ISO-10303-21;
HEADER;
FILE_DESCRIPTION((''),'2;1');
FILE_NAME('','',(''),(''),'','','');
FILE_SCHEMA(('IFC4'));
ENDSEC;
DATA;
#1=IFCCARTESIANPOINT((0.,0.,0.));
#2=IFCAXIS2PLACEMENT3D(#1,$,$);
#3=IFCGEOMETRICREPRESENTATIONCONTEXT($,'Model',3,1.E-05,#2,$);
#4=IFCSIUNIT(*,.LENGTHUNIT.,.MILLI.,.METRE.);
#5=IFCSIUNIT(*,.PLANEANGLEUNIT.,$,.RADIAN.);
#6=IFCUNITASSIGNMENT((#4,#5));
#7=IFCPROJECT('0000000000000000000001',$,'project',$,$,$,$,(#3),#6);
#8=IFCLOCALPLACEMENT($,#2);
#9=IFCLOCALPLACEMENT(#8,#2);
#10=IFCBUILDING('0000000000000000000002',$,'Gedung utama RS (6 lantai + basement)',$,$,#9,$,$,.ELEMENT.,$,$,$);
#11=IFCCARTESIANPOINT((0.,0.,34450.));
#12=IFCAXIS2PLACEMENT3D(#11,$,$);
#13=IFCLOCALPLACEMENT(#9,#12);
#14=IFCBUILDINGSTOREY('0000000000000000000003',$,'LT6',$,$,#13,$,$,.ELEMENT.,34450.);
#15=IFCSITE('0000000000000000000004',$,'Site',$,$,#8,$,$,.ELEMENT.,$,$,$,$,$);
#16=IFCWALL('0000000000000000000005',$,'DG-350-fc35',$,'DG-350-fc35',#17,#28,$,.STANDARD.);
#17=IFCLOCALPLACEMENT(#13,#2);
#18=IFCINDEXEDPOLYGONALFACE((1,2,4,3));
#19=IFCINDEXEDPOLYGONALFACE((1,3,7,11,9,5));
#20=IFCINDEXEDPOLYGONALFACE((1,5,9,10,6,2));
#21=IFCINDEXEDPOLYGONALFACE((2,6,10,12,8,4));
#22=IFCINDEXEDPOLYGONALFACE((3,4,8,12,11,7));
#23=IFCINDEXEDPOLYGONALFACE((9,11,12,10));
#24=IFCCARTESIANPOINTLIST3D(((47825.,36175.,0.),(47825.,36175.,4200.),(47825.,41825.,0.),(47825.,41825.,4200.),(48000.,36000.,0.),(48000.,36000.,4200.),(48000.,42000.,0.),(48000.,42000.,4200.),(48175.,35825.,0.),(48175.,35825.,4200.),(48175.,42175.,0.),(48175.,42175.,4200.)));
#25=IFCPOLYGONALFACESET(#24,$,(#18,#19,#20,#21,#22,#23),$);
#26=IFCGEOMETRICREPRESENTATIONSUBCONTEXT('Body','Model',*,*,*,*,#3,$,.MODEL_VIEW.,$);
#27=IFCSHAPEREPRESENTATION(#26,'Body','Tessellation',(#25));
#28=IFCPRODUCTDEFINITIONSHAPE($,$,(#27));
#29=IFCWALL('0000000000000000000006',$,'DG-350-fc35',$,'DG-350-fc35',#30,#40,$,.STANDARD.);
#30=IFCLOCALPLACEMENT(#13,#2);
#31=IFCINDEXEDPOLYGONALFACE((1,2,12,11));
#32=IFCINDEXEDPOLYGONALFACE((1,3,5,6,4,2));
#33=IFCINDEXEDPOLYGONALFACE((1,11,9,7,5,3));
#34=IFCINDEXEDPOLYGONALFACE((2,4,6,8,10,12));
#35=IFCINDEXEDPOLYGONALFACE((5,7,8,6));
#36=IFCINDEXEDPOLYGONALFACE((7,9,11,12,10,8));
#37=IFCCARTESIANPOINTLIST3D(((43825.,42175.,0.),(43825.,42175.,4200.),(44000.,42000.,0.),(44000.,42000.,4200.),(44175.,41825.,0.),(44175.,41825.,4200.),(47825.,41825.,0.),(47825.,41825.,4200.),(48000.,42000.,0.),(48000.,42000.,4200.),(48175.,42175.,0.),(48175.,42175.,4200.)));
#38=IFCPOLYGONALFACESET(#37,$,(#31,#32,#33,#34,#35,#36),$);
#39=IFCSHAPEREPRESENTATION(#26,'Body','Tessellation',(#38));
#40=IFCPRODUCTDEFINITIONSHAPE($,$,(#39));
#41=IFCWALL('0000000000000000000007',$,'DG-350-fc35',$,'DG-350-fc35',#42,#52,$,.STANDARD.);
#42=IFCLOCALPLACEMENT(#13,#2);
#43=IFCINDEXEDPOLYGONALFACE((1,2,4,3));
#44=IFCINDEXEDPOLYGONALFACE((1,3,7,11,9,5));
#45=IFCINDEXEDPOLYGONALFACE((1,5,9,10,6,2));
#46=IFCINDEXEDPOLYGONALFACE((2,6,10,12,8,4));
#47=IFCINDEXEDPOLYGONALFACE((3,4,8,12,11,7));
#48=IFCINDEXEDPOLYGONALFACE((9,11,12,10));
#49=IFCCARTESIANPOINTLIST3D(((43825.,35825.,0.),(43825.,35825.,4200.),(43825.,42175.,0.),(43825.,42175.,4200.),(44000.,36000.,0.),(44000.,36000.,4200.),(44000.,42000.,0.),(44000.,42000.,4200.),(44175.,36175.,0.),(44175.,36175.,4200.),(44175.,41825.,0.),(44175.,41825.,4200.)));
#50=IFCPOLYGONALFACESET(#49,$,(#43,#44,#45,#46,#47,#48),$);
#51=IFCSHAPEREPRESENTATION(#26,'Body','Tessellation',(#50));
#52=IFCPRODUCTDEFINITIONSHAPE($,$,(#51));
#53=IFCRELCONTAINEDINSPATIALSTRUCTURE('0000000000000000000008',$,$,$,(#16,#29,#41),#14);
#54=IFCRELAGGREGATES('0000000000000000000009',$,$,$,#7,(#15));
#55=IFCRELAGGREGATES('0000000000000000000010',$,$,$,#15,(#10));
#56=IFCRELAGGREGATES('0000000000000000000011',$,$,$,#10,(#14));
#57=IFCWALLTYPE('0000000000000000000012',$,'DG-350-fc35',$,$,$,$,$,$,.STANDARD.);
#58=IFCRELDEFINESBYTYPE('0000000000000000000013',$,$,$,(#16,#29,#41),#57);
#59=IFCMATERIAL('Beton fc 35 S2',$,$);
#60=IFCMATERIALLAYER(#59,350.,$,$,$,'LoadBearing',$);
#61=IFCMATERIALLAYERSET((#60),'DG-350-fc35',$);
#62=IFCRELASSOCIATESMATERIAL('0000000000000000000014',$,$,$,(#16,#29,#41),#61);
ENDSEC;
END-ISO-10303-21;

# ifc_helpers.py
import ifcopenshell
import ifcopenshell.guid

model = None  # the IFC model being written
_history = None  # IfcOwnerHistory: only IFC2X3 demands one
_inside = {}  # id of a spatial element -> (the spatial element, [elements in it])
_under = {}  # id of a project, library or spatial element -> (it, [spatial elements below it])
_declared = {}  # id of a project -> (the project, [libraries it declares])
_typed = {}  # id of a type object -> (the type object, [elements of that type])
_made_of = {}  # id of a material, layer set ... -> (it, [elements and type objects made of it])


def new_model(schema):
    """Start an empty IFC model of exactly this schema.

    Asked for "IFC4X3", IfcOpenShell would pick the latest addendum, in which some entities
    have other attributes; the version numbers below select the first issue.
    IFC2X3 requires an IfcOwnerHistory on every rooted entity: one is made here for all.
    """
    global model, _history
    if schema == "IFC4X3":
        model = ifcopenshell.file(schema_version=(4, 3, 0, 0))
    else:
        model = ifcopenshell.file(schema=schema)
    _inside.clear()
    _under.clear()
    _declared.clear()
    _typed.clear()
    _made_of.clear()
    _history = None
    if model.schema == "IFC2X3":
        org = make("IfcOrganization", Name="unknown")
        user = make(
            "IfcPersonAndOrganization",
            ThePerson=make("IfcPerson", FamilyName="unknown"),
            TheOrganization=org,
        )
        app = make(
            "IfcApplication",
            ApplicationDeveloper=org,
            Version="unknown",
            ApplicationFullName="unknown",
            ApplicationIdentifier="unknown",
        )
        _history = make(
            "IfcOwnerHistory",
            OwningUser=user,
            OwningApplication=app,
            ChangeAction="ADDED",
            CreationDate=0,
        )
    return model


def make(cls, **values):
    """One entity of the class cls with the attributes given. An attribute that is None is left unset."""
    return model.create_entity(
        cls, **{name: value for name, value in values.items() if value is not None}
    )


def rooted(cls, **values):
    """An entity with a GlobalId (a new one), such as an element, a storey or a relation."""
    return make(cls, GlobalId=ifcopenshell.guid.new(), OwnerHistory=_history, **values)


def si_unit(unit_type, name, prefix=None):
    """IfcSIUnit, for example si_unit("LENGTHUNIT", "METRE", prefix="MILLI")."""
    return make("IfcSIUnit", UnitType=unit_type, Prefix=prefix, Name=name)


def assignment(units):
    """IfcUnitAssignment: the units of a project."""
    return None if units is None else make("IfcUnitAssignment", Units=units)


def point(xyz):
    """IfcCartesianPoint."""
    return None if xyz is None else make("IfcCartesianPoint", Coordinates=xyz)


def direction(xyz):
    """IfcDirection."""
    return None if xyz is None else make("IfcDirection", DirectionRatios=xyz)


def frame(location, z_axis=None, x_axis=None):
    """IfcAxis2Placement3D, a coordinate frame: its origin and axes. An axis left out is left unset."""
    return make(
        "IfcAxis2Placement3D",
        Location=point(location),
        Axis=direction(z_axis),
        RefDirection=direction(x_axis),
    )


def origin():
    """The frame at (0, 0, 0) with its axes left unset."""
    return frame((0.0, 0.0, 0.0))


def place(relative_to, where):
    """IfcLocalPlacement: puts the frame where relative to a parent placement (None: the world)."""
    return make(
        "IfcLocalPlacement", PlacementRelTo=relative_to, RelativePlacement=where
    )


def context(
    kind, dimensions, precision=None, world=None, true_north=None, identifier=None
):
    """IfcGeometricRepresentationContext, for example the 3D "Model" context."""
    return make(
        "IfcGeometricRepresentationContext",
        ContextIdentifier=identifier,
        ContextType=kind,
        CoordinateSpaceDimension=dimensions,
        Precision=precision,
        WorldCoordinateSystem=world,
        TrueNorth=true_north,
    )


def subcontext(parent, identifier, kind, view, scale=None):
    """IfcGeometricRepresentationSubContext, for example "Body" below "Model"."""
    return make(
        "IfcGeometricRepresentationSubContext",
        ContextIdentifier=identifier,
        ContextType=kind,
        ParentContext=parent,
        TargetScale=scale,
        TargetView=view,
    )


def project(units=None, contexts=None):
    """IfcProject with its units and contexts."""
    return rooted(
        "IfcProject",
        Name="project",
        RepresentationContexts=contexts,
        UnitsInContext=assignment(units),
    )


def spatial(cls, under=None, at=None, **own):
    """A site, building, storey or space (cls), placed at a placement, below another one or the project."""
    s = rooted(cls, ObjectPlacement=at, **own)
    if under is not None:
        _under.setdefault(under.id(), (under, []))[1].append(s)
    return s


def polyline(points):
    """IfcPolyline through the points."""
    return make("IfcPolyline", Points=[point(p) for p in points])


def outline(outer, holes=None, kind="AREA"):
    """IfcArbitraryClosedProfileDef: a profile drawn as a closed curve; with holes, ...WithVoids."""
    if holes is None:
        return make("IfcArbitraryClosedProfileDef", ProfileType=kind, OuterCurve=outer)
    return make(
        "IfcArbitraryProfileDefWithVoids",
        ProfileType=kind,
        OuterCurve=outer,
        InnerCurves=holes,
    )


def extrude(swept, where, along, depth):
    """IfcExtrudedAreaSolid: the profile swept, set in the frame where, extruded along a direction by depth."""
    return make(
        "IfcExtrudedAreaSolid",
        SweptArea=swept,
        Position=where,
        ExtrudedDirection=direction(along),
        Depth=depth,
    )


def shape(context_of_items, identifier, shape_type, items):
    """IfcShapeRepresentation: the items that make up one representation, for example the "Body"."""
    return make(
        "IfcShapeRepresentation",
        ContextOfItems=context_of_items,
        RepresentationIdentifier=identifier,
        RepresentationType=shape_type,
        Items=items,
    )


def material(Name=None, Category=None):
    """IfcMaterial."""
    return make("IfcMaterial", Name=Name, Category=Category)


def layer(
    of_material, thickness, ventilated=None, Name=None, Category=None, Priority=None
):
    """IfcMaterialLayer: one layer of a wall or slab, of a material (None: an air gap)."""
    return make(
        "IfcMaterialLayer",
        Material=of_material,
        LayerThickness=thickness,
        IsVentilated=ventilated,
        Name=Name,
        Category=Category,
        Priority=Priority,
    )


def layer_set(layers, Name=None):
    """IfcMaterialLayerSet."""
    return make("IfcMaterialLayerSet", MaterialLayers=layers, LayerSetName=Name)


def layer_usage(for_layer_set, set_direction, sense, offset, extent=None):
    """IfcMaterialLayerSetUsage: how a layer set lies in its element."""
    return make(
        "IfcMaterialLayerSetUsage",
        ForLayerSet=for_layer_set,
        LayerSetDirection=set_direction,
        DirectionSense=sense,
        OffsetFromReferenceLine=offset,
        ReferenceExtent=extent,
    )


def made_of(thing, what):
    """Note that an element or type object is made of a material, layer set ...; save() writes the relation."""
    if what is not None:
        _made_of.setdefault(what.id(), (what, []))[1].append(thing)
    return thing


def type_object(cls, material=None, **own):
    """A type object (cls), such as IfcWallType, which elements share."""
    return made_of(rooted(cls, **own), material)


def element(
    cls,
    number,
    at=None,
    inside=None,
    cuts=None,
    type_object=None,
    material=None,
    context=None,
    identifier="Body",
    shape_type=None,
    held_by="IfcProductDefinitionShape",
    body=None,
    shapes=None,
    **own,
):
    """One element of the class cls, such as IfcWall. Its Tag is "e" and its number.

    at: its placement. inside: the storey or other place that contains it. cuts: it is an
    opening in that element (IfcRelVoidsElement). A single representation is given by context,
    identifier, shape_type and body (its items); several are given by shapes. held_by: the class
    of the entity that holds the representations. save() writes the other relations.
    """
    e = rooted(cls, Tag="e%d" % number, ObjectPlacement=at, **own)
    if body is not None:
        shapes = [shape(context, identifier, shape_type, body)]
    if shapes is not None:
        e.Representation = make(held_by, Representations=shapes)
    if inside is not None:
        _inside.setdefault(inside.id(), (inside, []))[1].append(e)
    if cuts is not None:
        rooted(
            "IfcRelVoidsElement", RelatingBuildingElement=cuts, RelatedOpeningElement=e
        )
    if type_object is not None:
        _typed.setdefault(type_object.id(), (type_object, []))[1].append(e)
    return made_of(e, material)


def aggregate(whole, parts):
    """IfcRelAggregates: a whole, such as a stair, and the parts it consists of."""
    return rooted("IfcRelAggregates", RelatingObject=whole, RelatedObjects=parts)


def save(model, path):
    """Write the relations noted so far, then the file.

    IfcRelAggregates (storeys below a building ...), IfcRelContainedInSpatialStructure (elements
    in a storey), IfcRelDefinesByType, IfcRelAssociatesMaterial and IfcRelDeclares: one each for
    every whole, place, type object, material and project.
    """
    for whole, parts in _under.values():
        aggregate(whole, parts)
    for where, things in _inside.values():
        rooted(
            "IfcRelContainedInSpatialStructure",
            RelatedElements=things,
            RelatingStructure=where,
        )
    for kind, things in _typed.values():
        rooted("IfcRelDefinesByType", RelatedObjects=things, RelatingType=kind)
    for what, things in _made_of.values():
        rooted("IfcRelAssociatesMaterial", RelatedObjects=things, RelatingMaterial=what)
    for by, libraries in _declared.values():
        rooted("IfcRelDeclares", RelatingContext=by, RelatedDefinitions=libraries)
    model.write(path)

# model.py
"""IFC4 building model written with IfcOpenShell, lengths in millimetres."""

from ifc_helpers import new_model, si_unit, frame, origin, place, context, subcontext, project, spatial, polyline, outline, extrude, material, layer, layer_set, layer_usage, type_object, element, save


model = new_model("IFC4")

# Units and contexts
model_context = context("Model", 3, precision=1e-05, world=origin())
body_context = subcontext(model_context, "Body", "Model", "MODEL_VIEW")
ifc_project = project(units=[si_unit("LENGTHUNIT", "METRE", prefix="MILLI"), si_unit("PLANEANGLEUNIT", "RADIAN")], contexts=[model_context])

# Site, building, storey
site_placement = place(None, origin())
site = spatial("IfcSite", under=ifc_project, at=site_placement, Name="Site", CompositionType="ELEMENT")
building_placement = place(site_placement, origin())
building = spatial("IfcBuilding", under=site, at=building_placement, Name="Gedung utama RS (6 lantai + basement)", CompositionType="ELEMENT")
storey_placement = place(building_placement, frame((0.0, 0.0, 34450.0)))
storey = spatial("IfcBuildingStorey", under=building, at=storey_placement, Name="LT6", CompositionType="ELEMENT", Elevation=34450.0)

# Shared definitions
ifc_material_1 = material(Name="Beton fc 35 S2")
ifc_layer = layer(ifc_material_1, 350.0, Category="LoadBearing")
ifc_layer_set = layer_set([ifc_layer], Name="DG-350-fc35")
ifc_layer_usage = layer_usage(ifc_layer_set, "AXIS2", "NEGATIVE", 175.0)
wall_type = type_object("IfcWallType", Name="DG-350-fc35", PredefinedType="STANDARD")

# Walls
wall_1_placement = place(storey_placement, frame((48000.0, 36000.0, 0.0), z_axis=(0.0, 0.0, 1.0), x_axis=(0.0, 1.0, 0.0)))
element("IfcWall", 1, at=wall_1_placement, inside=storey, type_object=wall_type, material=ifc_layer_usage, Name="DG-350-fc35", ObjectType="DG-350-fc35", PredefinedType="STANDARD", context=body_context, shape_type="SweptSolid", body=[
    extrude(outline(polyline([(-175.0, -175.0), (0.0, 0.0), (175.0, 175.0), (5825.0, 175.0), (6000.0, 0.0), (6175.0, -175.0), (-175.0, -175.0)])), origin(), (0.0, 0.0, 1.0), 4200.0),
])
wall_2_placement = place(storey_placement, frame((48000.0, 42000.0, 0.0), z_axis=(0.0, 0.0, 1.0), x_axis=(-1.0, 0.0, 0.0)))
element("IfcWall", 2, at=wall_2_placement, inside=storey, type_object=wall_type, material=ifc_layer_usage, Name="DG-350-fc35", ObjectType="DG-350-fc35", PredefinedType="STANDARD", context=body_context, shape_type="SweptSolid", body=[
    extrude(outline(polyline([(-175.0, -175.0), (0.0, 0.0), (175.0, 175.0), (3825.0, 175.0), (4000.0, 0.0), (4175.0, -175.0), (-175.0, -175.0)])), origin(), (0.0, 0.0, 1.0), 4200.0),
])
wall_3_placement = place(storey_placement, frame((44000.0, 42000.0, 0.0), z_axis=(0.0, 0.0, 1.0), x_axis=(0.0, -1.0, 0.0)))
element("IfcWall", 3, at=wall_3_placement, inside=storey, type_object=wall_type, material=ifc_layer_usage, Name="DG-350-fc35", ObjectType="DG-350-fc35", PredefinedType="STANDARD", context=body_context, shape_type="SweptSolid", body=[
    extrude(outline(polyline([(-175.0, -175.0), (0.0, 0.0), (175.0, 175.0), (5825.0, 175.0), (6000.0, 0.0), (6175.0, -175.0), (-175.0, -175.0)])), origin(), (0.0, 0.0, 1.0), 4200.0),
])

save(model, "model.ifc")
